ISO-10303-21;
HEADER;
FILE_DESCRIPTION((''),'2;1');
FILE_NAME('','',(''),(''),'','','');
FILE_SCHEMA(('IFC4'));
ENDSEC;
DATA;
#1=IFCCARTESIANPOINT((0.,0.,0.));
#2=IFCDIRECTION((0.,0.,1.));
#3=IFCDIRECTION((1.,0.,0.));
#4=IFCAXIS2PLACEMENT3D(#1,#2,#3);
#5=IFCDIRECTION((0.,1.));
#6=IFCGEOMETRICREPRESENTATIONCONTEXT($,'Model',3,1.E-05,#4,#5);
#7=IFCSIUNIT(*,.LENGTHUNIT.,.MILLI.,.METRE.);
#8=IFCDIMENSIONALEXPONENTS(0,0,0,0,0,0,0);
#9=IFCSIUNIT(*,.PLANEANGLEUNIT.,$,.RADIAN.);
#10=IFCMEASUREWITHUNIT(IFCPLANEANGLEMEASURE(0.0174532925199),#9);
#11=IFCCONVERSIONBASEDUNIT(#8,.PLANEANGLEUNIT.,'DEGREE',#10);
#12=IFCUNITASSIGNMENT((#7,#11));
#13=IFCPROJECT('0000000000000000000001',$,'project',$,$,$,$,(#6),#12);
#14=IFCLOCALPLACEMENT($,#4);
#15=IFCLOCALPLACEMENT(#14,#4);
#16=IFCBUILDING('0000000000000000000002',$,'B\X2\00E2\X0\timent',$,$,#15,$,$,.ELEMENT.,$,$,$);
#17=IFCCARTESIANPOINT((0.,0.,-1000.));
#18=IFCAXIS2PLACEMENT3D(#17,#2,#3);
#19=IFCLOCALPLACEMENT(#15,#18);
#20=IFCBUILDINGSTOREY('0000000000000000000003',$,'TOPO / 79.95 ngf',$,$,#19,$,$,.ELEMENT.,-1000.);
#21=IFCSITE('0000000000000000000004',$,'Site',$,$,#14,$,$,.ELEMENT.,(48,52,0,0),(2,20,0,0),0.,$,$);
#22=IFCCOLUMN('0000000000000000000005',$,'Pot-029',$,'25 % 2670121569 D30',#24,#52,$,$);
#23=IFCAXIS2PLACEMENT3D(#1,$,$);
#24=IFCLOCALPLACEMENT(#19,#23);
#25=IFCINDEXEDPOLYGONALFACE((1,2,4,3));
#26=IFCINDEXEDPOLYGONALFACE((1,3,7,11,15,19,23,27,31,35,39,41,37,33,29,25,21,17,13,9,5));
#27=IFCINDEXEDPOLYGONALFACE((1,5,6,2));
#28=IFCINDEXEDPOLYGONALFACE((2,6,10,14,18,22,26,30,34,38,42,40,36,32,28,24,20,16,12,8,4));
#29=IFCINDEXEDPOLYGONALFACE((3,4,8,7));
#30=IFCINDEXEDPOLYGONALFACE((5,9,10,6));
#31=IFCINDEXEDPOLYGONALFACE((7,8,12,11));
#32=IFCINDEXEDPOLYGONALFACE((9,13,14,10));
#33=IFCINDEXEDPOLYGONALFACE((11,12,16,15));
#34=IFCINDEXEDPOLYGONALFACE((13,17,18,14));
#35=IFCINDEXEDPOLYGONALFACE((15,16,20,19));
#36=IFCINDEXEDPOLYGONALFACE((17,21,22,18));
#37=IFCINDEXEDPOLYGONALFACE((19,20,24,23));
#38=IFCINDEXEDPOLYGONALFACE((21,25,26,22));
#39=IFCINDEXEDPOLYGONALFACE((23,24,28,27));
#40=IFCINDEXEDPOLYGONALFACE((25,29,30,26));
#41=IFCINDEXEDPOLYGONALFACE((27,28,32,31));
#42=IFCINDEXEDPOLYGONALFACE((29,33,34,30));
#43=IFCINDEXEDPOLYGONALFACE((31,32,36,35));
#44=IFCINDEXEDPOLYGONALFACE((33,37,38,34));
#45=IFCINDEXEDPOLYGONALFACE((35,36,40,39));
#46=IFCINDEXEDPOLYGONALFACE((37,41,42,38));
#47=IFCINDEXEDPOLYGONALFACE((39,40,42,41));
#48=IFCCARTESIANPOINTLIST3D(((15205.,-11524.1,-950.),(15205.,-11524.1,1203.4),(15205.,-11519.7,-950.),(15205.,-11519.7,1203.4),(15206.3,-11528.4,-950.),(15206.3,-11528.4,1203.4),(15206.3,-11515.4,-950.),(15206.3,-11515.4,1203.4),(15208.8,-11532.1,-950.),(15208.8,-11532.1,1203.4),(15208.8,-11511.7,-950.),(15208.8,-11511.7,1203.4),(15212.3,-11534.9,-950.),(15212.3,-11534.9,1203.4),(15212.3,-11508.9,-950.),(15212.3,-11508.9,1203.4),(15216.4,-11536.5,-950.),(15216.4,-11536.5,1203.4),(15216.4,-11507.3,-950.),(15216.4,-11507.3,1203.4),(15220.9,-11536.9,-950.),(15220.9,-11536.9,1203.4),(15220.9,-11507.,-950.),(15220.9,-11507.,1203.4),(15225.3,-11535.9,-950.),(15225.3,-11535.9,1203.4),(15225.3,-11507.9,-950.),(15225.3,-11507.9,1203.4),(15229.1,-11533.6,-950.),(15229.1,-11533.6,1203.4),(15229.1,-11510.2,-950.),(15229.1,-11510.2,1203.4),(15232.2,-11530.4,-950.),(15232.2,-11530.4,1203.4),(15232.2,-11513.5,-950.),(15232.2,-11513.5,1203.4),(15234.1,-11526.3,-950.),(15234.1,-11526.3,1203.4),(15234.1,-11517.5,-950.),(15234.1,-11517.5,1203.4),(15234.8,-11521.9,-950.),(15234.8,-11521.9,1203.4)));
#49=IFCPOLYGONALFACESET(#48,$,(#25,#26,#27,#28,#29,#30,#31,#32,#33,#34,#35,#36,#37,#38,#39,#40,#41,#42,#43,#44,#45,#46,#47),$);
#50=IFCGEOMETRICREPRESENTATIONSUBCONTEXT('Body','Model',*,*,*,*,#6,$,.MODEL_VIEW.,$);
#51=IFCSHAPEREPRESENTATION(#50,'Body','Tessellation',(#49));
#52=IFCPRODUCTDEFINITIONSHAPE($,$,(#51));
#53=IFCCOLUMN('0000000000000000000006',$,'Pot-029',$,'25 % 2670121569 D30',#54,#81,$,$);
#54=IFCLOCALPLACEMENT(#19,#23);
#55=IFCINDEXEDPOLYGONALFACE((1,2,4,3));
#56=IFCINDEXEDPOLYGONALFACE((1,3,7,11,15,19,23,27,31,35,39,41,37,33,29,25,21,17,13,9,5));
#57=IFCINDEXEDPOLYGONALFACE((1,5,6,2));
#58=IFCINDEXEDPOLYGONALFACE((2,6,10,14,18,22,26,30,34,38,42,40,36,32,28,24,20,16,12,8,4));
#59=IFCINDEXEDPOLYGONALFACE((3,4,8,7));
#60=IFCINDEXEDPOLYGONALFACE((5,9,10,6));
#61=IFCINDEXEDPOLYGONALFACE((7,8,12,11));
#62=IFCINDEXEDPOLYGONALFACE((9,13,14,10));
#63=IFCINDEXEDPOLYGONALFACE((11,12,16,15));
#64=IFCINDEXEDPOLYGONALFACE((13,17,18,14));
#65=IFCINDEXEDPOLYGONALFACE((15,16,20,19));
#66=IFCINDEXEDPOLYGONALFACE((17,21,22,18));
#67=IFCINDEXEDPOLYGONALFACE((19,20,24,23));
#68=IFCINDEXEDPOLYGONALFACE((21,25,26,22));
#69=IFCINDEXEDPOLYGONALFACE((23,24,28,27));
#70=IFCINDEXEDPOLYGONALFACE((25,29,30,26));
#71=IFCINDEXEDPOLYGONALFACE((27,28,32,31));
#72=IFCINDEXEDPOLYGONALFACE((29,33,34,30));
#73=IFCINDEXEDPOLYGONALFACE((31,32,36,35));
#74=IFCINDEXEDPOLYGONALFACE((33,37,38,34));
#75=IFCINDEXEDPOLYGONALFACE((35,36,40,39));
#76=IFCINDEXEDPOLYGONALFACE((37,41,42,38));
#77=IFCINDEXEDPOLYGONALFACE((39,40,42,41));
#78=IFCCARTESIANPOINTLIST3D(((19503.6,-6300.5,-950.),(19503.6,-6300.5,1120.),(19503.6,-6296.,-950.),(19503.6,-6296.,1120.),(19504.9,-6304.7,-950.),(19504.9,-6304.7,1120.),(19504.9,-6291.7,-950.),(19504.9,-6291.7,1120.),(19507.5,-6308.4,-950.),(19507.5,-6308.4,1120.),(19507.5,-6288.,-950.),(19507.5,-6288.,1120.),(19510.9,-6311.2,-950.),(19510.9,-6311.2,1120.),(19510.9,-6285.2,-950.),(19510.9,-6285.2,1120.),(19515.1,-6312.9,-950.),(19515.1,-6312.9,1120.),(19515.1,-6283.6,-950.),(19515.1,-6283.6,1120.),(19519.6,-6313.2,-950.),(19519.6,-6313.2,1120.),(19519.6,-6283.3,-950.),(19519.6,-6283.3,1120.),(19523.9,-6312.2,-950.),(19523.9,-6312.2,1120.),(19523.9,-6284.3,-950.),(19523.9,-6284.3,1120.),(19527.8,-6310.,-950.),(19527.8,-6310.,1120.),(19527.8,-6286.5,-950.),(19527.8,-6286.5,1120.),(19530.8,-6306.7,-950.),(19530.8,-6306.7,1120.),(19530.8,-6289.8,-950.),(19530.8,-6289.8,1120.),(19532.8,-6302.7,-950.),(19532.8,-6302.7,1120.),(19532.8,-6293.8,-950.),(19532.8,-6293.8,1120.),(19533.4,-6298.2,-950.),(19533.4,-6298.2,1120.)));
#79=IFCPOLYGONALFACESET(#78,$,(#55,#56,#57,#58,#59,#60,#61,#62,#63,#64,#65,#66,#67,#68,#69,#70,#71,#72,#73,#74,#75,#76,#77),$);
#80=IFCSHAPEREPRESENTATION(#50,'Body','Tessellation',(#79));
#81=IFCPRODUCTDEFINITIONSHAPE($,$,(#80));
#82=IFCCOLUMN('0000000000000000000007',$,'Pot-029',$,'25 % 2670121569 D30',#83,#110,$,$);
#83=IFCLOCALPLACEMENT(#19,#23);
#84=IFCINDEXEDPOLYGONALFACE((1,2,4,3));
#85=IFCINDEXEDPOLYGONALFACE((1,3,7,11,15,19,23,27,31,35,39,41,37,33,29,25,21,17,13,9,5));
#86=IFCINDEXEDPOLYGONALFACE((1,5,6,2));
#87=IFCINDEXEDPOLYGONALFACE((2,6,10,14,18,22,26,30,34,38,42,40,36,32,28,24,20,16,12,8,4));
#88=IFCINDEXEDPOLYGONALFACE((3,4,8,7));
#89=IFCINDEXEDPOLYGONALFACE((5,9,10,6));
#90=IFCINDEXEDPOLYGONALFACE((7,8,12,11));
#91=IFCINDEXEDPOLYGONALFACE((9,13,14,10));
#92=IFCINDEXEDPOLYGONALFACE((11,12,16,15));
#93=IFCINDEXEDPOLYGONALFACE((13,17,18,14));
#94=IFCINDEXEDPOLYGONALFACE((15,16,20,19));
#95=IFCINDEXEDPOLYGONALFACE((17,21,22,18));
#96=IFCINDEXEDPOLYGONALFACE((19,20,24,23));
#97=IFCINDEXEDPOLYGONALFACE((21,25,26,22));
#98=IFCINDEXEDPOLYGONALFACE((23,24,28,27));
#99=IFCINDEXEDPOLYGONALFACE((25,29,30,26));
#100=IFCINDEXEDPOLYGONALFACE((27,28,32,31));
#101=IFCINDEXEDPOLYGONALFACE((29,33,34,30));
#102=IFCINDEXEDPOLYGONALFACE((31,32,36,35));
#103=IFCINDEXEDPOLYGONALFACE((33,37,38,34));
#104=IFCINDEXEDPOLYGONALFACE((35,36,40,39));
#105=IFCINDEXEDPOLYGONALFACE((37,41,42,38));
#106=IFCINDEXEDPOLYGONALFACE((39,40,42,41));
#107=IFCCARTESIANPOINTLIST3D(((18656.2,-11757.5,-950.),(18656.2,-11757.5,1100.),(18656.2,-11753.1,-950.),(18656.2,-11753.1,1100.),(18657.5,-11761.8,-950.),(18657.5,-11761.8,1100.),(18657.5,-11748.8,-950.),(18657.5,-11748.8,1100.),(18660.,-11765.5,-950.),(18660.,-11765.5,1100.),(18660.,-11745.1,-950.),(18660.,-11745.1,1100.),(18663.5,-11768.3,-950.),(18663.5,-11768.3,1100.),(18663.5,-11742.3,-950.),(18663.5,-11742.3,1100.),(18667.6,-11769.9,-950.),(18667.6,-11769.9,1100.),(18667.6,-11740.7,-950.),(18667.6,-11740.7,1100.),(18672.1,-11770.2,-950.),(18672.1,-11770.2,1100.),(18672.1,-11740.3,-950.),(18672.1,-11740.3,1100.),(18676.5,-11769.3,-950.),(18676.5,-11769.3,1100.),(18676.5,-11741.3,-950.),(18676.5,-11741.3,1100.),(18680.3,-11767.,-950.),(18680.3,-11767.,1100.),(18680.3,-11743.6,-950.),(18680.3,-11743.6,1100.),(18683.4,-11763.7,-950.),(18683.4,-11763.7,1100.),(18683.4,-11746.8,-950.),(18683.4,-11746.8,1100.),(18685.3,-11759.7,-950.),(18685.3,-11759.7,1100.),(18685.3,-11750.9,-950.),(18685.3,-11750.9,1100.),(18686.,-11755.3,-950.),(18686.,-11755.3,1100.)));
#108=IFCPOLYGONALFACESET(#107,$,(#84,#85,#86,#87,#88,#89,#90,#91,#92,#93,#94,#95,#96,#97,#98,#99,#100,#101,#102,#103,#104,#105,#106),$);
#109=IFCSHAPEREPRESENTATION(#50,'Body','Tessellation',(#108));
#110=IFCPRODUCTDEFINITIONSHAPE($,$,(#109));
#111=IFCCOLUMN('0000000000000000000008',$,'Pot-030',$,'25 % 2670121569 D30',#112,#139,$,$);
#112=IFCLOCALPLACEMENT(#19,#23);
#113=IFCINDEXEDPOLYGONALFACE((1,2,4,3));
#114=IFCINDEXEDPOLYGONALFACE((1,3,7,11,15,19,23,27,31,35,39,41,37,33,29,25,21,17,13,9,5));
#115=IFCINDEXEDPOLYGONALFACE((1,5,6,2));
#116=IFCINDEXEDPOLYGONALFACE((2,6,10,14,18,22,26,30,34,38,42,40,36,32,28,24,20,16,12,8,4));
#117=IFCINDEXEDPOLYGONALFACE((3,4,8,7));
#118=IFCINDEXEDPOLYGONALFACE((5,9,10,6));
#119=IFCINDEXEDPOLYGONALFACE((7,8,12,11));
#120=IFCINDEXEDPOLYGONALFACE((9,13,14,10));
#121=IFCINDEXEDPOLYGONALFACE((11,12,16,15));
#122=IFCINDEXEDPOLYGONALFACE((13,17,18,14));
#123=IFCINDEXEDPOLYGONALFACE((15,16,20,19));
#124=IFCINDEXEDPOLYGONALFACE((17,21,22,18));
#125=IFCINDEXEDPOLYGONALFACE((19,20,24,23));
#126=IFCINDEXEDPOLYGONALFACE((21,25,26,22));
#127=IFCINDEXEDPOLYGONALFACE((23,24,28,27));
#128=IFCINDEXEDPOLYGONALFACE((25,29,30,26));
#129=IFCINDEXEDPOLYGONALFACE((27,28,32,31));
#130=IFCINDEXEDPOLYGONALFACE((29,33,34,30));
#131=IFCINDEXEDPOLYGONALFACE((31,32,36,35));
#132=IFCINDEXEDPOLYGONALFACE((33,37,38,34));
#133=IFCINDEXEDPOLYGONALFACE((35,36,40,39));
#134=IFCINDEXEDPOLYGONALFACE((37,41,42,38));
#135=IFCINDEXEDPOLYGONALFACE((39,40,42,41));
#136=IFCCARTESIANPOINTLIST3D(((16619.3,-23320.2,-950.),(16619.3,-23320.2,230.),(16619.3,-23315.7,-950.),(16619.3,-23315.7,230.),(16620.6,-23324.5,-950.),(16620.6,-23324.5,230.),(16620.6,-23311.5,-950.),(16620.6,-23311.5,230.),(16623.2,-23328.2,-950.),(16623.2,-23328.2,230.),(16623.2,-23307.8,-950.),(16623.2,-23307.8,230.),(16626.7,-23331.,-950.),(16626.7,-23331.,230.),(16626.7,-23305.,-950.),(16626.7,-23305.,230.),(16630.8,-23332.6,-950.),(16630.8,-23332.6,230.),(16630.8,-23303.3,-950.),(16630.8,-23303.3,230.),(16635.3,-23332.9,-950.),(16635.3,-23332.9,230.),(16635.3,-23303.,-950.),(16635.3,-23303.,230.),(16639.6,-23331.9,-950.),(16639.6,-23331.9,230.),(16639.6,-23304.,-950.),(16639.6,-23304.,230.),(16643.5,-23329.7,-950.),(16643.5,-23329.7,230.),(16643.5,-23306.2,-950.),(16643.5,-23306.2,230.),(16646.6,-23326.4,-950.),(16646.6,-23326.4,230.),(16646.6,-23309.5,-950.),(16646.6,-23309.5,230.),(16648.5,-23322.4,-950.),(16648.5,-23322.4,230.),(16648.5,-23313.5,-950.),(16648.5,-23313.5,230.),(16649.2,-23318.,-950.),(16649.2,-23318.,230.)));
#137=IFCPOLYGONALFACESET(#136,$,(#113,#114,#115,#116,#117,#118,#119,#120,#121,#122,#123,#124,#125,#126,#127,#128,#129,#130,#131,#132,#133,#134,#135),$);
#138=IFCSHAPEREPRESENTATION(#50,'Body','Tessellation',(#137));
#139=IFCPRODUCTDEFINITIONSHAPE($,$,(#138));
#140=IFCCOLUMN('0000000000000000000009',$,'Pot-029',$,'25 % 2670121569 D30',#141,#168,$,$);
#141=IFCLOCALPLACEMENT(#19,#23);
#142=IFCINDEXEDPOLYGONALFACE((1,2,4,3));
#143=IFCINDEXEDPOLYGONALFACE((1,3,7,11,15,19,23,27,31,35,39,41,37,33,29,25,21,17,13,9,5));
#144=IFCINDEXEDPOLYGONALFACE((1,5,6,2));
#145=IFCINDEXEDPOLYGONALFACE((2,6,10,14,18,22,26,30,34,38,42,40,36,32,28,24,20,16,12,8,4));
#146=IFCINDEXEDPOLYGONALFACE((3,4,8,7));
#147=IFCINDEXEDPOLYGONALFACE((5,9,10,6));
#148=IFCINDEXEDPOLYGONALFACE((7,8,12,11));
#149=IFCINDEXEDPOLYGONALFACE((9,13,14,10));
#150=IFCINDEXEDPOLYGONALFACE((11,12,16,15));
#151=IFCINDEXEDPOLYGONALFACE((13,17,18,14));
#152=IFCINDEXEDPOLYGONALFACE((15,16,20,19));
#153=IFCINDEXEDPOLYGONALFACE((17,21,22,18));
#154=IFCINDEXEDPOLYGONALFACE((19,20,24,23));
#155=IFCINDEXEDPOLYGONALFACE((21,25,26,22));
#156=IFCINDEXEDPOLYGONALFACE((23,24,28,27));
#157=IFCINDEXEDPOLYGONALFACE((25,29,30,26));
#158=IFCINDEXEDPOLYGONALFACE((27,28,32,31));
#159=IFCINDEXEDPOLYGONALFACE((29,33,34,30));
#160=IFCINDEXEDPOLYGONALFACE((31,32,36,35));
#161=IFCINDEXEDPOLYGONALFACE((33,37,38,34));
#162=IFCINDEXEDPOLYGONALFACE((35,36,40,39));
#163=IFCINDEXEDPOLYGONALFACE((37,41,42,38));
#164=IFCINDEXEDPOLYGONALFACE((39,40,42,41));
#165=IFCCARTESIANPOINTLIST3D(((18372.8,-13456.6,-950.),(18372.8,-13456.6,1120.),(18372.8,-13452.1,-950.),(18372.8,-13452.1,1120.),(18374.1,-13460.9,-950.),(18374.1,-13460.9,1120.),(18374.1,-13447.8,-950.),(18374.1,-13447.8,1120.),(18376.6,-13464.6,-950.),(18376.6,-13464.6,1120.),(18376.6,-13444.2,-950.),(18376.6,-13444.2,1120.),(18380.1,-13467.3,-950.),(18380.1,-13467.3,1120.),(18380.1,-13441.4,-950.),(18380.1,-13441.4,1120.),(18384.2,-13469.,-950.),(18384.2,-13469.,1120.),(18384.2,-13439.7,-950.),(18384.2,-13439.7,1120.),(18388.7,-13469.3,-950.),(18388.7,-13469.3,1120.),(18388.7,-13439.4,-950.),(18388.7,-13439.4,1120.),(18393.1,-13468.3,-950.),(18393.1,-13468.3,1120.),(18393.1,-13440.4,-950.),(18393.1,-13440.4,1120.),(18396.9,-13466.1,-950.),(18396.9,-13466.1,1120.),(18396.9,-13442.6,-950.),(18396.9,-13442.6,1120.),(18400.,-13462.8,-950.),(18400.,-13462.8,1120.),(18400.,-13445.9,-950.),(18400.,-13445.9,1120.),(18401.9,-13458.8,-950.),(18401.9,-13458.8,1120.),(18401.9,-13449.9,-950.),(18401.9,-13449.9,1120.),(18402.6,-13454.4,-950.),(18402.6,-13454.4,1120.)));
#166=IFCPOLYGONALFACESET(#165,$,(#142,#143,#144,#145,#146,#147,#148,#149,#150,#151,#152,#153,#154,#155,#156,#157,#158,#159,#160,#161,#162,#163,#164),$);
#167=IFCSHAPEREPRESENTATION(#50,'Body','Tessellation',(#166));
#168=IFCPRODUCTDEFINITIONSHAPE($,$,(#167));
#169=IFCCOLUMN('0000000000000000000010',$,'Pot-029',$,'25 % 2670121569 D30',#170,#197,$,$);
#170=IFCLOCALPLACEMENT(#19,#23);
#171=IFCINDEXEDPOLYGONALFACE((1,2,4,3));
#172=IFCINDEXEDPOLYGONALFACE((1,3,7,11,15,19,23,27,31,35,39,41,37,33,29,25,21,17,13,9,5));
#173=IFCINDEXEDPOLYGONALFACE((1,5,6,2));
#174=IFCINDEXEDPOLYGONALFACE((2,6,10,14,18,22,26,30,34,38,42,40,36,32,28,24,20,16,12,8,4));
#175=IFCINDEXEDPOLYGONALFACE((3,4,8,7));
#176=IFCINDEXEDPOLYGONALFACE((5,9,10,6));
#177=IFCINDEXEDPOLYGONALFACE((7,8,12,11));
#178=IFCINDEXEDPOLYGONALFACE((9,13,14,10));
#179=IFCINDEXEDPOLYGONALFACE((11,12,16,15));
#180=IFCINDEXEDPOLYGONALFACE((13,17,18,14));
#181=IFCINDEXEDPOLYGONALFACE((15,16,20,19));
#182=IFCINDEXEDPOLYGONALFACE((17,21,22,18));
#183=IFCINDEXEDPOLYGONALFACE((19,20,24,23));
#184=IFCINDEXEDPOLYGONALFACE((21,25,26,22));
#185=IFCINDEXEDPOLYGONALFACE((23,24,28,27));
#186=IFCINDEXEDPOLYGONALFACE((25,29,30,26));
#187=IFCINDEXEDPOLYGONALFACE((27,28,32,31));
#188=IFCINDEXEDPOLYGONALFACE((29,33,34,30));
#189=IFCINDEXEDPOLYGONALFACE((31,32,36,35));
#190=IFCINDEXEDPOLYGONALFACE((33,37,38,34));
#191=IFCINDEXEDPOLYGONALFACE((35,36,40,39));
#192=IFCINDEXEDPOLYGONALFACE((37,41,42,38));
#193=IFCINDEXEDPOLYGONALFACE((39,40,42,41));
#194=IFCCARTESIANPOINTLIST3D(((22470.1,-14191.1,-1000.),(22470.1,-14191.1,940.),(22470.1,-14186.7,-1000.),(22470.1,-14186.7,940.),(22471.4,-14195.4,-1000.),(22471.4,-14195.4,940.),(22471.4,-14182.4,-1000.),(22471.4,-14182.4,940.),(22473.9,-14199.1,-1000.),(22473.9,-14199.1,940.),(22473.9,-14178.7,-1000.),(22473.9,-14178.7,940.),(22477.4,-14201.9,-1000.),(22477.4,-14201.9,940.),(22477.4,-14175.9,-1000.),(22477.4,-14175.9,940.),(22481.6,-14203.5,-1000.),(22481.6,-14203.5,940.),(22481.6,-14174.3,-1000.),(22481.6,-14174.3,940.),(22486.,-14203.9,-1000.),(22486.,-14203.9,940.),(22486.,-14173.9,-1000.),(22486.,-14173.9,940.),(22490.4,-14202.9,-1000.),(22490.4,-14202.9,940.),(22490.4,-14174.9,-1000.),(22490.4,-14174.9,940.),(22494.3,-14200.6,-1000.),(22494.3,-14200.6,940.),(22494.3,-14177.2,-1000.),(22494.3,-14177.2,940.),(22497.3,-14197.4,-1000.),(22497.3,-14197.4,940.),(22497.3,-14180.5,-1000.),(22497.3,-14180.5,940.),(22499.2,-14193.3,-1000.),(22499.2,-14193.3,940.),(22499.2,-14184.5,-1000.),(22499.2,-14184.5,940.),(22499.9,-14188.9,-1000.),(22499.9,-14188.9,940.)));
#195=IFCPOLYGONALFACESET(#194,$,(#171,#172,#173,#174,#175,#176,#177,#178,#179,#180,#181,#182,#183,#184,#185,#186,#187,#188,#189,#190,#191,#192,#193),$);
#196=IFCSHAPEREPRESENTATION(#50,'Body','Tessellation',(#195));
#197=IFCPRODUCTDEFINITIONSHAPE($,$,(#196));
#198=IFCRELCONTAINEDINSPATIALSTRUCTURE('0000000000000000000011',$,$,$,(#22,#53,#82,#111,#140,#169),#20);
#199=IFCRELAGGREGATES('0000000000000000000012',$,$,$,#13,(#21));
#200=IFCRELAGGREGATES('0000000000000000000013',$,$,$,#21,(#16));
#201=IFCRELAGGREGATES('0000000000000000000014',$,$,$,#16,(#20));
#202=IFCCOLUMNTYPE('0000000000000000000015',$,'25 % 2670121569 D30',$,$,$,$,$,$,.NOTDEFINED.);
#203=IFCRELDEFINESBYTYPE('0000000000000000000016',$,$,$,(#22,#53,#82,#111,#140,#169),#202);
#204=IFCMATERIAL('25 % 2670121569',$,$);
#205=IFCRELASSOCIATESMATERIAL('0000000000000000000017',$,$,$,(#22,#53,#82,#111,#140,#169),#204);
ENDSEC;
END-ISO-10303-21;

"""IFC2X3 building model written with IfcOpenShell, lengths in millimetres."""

from ifc_helpers import new_model, entity, si_unit, converted_unit, direction, frame, origin_with_axes, origin_2d_with_axis, place, context, subcontext, project, spatial, circle, extrude, material, type_object, element, save


model = new_model("IFC2X3")

# Units and contexts
model_context = context("Model", 3, precision=1e-05, world=origin_with_axes(), true_north=direction((0.0, 1.0)))
body_context = subcontext(model_context, "Body", "Model", "MODEL_VIEW")
ifc_project = project(units=[si_unit("LENGTHUNIT", "METRE", prefix="MILLI"), converted_unit("PLANEANGLEUNIT", "DEGREE", entity("IfcPlaneAngleMeasure", 0.0174532925199), si_unit("PLANEANGLEUNIT", "RADIAN"), dimensions=[0, 0, 0, 0, 0, 0, 0])], contexts=[model_context])

# Site, building, storey
site_placement = place(None, origin_with_axes())
site = spatial("IfcSite", under=ifc_project, at=site_placement, Name="Site", CompositionType="ELEMENT", RefLatitude=(48, 52, 0, 0), RefLongitude=(2, 20, 0, 0), RefElevation=0.0)
building_placement = place(site_placement, origin_with_axes())
building = spatial("IfcBuilding", under=site, at=building_placement, Name="Bâtiment", CompositionType="ELEMENT")
storey_placement = place(building_placement, frame((0.0, 0.0, -1000.0), z_axis=(0.0, 0.0, 1.0), x_axis=(1.0, 0.0, 0.0)))
storey = spatial("IfcBuildingStorey", under=building, at=storey_placement, Name="TOPO / 79.95 ngf", CompositionType="ELEMENT", Elevation=-1000.0)

# Columns
ifc_material_1 = material(Name="25 % 2670121569")
column_type = type_object("IfcColumnType", Name="25 % 2670121569 D30", PredefinedType="NOTDEFINED")
column_1_placement = place(storey_placement, frame((15219.8, -11521.9, -950.0), z_axis=(0.0, 0.0, 1.0), x_axis=(1.0, 0.0, 0.0)))
element("IfcColumn", 1, at=column_1_placement, inside=storey, type_object=column_type, material=ifc_material_1, Name="Pot-029", ObjectType="25 % 2670121569 D30", context=body_context, shape_type="SweptSolid", body=[
    extrude(circle(Radius=15.0, at=origin_2d_with_axis()), origin_with_axes(), (0.0, 0.0, 1.0), 2153.4),
])
column_2_placement = place(storey_placement, frame((19518.4, -6298.2, -950.0), z_axis=(0.0, 0.0, 1.0), x_axis=(1.0, 0.0, 0.0)))
element("IfcColumn", 2, at=column_2_placement, inside=storey, type_object=column_type, material=ifc_material_1, Name="Pot-029", ObjectType="25 % 2670121569 D30", context=body_context, shape_type="SweptSolid", body=[
    extrude(circle(Radius=15.0, at=origin_2d_with_axis()), origin_with_axes(), (0.0, 0.0, 1.0), 2070.0),
])
column_3_placement = place(storey_placement, frame((18671.0, -11755.3, -950.0), z_axis=(0.0, 0.0, 1.0), x_axis=(1.0, 0.0, 0.0)))
element("IfcColumn", 3, at=column_3_placement, inside=storey, type_object=column_type, material=ifc_material_1, Name="Pot-029", ObjectType="25 % 2670121569 D30", context=body_context, shape_type="SweptSolid", body=[
    extrude(circle(Radius=15.0, at=origin_2d_with_axis()), origin_with_axes(), (0.0, 0.0, 1.0), 2050.0),
])
column_4_placement = place(storey_placement, frame((16634.2, -23318.0, -950.0), z_axis=(0.0, 0.0, 1.0), x_axis=(1.0, 0.0, 0.0)))
element("IfcColumn", 4, at=column_4_placement, inside=storey, type_object=column_type, material=ifc_material_1, Name="Pot-030", ObjectType="25 % 2670121569 D30", context=body_context, shape_type="SweptSolid", body=[
    extrude(circle(Radius=15.0, at=origin_2d_with_axis()), origin_with_axes(), (0.0, 0.0, 1.0), 1180.0),
])
column_5_placement = place(storey_placement, frame((18387.6, -13454.4, -950.0), z_axis=(0.0, 0.0, 1.0), x_axis=(1.0, 0.0, 0.0)))
element("IfcColumn", 5, at=column_5_placement, inside=storey, type_object=column_type, material=ifc_material_1, Name="Pot-029", ObjectType="25 % 2670121569 D30", context=body_context, shape_type="SweptSolid", body=[
    extrude(circle(Radius=15.0, at=origin_2d_with_axis()), origin_with_axes(), (0.0, 0.0, 1.0), 2070.0),
])
column_6_placement = place(storey_placement, frame((22484.9, -14188.9, -1000.0), z_axis=(0.0, 0.0, 1.0), x_axis=(1.0, 0.0, 0.0)))
element("IfcColumn", 6, at=column_6_placement, inside=storey, type_object=column_type, material=ifc_material_1, Name="Pot-029", ObjectType="25 % 2670121569 D30", context=body_context, shape_type="SweptSolid", body=[
    extrude(circle(Radius=15.0, at=origin_2d_with_axis()), origin_with_axes(), (0.0, 0.0, 1.0), 1940.0),
])

save(model, "model.ifc")
